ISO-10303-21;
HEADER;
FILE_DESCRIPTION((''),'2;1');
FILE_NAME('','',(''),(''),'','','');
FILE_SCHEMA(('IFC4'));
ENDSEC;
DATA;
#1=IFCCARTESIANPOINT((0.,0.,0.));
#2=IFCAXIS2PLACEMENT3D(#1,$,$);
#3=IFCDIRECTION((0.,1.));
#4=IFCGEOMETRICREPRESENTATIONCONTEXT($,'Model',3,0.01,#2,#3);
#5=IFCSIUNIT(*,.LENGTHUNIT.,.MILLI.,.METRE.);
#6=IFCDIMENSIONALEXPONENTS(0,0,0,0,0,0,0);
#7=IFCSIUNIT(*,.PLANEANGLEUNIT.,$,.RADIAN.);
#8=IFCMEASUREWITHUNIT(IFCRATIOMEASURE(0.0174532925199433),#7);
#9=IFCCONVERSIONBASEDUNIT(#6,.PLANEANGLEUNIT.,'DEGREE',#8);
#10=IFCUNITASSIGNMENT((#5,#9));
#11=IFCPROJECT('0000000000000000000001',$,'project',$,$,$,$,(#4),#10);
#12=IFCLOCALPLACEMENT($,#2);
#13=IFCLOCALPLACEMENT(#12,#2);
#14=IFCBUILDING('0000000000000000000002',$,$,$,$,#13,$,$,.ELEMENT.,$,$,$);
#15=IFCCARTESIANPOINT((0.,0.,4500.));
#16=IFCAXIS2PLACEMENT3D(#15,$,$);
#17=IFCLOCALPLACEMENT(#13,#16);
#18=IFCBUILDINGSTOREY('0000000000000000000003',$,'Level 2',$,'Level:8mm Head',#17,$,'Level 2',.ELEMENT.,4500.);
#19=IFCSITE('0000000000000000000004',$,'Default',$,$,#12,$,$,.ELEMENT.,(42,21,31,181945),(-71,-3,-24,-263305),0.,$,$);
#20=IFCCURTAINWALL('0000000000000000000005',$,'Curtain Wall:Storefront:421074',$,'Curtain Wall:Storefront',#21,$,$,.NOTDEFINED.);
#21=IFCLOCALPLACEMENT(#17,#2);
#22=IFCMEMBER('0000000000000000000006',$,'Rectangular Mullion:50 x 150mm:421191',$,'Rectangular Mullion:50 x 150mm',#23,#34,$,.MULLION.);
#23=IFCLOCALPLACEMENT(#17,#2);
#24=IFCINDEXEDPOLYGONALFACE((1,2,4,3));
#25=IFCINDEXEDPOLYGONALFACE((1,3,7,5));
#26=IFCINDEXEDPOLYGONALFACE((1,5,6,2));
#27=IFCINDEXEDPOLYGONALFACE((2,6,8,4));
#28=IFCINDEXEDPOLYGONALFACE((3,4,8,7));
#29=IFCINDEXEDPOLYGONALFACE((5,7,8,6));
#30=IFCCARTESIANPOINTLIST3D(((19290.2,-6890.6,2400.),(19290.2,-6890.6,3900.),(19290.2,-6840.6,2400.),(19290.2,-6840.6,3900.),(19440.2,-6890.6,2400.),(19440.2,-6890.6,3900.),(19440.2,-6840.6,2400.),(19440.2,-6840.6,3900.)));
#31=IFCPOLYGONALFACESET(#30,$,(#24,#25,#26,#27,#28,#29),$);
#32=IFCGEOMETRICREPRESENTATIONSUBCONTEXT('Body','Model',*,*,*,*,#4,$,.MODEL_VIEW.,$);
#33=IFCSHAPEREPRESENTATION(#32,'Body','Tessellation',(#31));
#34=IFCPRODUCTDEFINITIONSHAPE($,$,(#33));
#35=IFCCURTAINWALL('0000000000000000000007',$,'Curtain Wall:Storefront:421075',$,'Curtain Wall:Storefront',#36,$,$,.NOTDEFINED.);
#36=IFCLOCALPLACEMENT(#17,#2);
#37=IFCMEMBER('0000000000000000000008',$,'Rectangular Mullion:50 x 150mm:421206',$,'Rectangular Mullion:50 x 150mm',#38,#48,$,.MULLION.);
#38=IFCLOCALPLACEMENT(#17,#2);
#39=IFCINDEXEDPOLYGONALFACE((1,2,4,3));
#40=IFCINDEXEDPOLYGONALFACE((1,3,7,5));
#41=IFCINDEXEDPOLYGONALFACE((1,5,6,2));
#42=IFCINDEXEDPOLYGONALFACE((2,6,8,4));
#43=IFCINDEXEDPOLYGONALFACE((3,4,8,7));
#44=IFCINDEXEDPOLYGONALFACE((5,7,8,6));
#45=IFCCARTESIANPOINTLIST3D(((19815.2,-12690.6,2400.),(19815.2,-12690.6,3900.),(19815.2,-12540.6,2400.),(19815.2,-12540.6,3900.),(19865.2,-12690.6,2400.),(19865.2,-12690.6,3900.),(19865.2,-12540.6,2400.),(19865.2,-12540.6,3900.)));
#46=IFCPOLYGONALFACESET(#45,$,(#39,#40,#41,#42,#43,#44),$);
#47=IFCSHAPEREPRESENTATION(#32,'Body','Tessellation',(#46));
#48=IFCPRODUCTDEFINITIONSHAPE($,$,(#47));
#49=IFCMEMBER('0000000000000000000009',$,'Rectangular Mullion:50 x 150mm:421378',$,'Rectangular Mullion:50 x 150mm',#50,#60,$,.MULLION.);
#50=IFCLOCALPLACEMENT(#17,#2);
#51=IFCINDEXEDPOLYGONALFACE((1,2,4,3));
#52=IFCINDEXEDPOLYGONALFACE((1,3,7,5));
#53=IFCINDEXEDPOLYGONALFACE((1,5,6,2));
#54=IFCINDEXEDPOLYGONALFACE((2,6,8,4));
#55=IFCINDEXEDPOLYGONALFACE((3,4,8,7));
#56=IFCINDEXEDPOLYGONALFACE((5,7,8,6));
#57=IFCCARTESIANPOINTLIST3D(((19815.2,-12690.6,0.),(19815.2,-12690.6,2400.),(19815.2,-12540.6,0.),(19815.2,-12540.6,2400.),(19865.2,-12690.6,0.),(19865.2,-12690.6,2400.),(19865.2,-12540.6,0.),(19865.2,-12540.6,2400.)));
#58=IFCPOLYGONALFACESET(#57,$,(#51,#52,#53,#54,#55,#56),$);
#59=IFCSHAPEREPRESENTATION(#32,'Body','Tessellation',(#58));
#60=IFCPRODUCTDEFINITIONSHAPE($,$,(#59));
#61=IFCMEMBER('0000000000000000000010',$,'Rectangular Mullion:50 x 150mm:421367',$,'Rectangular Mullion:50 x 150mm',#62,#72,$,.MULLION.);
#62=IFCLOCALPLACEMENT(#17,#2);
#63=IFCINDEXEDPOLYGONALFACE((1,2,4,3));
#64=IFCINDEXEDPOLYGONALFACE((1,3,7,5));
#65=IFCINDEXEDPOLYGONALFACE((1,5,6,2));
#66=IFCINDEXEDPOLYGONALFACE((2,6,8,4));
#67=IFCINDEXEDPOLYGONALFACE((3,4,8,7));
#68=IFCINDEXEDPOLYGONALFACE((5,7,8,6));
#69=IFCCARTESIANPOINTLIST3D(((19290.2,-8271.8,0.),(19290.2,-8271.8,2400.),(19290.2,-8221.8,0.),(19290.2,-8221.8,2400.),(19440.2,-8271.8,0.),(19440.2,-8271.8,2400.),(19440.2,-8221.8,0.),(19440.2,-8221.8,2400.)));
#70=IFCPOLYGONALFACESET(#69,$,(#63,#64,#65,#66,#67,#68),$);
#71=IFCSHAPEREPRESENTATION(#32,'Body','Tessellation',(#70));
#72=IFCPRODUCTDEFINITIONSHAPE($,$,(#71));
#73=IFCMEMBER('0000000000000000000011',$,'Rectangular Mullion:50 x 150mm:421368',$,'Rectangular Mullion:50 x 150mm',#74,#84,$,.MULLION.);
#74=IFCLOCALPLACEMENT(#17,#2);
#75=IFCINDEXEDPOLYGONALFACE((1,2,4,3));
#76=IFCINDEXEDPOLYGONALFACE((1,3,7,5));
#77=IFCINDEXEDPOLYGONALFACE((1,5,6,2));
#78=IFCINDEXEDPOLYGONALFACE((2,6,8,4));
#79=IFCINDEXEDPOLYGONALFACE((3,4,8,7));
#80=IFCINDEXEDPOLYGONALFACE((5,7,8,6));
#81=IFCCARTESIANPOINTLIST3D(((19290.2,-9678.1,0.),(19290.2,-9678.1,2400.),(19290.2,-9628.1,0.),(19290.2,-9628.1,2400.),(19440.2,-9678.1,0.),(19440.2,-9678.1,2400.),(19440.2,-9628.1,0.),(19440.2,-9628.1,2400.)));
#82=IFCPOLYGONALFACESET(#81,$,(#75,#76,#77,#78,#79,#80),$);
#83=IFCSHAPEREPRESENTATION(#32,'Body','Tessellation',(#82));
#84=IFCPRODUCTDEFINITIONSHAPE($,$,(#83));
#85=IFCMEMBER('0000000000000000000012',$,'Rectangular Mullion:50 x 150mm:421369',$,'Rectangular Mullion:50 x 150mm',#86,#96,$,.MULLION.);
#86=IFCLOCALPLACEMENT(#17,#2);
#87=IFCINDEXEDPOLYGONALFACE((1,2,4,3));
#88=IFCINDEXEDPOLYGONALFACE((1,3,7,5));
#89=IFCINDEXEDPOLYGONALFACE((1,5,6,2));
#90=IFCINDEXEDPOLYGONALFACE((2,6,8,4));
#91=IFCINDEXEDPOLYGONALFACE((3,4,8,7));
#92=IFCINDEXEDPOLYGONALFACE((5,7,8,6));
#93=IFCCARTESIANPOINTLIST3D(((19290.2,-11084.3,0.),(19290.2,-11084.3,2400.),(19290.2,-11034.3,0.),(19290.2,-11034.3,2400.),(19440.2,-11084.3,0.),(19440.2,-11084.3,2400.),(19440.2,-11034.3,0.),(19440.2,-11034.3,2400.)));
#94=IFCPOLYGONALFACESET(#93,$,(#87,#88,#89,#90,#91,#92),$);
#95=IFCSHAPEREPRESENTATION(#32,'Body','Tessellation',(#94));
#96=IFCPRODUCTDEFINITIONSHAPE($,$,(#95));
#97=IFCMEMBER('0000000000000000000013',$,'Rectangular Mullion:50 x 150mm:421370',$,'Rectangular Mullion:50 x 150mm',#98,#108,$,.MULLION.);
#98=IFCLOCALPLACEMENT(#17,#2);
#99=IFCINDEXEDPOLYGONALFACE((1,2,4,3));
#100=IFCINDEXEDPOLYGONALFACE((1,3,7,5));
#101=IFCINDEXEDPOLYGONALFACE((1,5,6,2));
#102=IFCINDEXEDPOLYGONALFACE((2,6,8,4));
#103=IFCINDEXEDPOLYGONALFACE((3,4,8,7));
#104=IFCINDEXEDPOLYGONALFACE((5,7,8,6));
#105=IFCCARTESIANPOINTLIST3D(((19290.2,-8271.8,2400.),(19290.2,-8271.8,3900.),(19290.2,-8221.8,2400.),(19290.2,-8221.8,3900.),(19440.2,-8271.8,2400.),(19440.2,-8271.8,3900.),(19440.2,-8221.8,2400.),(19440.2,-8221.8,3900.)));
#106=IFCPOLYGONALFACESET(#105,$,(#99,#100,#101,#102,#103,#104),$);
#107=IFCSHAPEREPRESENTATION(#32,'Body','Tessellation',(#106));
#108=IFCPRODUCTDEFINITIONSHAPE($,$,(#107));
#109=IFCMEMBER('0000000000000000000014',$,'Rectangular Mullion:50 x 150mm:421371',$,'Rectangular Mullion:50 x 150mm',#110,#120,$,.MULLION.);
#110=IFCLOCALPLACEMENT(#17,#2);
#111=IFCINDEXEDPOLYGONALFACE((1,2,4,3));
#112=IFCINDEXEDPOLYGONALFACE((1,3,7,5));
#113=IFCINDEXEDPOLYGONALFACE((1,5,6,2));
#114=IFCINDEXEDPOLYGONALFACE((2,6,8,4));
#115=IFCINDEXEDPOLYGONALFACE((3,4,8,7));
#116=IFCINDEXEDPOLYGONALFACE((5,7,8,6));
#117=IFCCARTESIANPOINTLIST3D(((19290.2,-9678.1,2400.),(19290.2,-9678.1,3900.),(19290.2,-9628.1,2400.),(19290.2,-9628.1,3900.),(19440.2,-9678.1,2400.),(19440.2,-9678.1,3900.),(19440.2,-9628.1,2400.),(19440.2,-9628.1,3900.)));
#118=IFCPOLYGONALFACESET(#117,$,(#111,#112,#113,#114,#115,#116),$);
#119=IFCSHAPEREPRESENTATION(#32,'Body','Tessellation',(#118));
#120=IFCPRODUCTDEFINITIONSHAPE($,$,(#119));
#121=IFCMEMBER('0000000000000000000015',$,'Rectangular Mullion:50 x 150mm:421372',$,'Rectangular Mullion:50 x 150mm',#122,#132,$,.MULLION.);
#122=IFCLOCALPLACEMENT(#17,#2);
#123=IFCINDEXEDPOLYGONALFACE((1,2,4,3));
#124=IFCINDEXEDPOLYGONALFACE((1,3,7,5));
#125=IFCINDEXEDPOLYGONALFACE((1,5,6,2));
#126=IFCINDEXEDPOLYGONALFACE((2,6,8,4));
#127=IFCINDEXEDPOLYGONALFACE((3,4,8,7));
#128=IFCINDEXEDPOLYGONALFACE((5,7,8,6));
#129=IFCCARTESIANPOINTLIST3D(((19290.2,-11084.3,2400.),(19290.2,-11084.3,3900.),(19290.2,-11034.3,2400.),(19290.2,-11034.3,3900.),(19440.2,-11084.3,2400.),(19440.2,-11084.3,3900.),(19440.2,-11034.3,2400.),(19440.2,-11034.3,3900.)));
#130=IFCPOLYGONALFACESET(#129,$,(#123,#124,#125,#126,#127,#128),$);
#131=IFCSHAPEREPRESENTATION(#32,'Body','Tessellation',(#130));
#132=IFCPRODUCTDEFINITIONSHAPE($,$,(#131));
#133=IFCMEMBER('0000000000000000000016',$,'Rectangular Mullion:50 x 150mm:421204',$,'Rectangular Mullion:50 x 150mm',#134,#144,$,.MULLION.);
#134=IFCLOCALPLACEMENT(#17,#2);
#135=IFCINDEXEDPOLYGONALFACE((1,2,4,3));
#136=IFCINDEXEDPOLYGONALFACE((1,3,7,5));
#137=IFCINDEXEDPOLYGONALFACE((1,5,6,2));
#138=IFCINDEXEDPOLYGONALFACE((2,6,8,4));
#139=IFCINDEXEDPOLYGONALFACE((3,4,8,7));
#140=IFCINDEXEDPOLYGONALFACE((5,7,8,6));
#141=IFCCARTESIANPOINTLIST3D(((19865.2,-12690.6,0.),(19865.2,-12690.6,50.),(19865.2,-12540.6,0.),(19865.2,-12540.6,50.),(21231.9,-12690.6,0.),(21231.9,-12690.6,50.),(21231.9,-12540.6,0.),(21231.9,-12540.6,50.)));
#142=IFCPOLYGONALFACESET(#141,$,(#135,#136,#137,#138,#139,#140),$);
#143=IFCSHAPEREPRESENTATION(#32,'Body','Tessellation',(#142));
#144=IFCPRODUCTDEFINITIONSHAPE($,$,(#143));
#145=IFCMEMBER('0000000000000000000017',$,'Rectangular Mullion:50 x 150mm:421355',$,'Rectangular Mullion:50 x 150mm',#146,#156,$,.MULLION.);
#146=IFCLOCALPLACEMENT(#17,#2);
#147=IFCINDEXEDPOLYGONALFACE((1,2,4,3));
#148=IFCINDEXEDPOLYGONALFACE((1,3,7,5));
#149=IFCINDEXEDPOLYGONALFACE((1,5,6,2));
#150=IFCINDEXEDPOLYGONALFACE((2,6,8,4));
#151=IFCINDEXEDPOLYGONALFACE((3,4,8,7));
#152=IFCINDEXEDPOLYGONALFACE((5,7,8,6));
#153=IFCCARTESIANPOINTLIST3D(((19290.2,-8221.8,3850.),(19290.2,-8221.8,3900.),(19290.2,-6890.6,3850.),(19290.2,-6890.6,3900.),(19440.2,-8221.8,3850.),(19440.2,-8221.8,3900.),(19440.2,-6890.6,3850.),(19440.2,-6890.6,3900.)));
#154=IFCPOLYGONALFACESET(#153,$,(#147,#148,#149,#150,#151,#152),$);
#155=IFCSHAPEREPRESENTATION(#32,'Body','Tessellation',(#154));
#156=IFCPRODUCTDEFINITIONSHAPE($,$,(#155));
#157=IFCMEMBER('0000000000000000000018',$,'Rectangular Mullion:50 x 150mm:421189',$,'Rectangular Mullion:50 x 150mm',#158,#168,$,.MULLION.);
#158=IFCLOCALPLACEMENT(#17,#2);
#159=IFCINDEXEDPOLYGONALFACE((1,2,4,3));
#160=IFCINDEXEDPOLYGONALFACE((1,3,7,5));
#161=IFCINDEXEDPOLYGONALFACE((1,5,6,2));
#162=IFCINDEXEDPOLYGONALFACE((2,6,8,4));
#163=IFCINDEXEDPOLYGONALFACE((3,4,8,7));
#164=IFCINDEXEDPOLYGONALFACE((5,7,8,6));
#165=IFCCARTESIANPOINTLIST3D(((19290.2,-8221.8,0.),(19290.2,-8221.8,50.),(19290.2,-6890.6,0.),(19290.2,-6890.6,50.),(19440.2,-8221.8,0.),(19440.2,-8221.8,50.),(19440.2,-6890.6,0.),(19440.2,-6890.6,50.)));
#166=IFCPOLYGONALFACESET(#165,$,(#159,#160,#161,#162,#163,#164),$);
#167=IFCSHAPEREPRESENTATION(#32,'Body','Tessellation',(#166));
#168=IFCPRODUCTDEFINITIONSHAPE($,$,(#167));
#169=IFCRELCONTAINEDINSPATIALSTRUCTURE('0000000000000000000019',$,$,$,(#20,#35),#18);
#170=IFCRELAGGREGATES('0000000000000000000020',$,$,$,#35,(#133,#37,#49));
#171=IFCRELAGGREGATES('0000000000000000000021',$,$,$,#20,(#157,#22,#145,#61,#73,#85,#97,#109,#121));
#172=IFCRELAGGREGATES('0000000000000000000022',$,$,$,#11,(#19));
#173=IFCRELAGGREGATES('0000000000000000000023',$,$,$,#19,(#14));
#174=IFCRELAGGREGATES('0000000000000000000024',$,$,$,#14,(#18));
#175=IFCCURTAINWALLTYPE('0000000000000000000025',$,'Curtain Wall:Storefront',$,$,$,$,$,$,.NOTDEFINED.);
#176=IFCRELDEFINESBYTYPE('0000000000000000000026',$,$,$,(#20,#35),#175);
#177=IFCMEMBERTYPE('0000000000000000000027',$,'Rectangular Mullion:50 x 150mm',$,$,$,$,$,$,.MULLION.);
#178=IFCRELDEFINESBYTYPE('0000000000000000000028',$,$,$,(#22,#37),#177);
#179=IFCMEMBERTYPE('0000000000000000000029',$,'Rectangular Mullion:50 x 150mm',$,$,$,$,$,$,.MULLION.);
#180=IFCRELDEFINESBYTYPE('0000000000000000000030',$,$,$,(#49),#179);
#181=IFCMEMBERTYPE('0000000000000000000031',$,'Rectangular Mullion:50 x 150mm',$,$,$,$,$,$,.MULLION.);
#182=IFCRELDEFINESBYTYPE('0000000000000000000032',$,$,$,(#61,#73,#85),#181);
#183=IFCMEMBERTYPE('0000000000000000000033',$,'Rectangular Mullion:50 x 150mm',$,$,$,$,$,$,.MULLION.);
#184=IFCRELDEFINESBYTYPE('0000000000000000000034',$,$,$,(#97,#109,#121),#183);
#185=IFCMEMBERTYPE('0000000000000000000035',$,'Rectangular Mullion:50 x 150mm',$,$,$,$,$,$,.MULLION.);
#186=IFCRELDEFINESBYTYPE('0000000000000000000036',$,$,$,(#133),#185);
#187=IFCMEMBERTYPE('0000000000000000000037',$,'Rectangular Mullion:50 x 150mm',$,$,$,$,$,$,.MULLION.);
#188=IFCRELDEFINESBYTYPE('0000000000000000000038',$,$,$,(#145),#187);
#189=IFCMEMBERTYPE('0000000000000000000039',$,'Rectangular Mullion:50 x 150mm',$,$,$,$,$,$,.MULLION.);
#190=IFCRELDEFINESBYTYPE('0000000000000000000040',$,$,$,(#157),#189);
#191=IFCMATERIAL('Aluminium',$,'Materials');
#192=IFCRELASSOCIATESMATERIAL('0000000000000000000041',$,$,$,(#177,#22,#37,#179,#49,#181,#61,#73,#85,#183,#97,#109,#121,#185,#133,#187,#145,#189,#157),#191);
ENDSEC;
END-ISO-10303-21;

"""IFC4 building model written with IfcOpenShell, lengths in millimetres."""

from ifc_helpers import new_model, entity, si_unit, converted_unit, direction, frame, origin, place, context, subcontext, project, spatial, indexed_curve, outline, extrude, source, transform, mapped, material, type_object, type_shapes, element, aggregate, save


model = new_model("IFC4")

# Units and contexts
model_context = context("Model", 3, precision=0.01, world=origin(), true_north=direction((0.0, 1.0)))
body_context = subcontext(model_context, "Body", "Model", "MODEL_VIEW")
ifc_project = project(units=[si_unit("LENGTHUNIT", "METRE", prefix="MILLI"), converted_unit("PLANEANGLEUNIT", "DEGREE", entity("IfcRatioMeasure", 0.0174532925199433), si_unit("PLANEANGLEUNIT", "RADIAN"), dimensions=[0, 0, 0, 0, 0, 0, 0])], contexts=[model_context])

# Site, building, storey
site_placement = place(None, origin())
site = spatial("IfcSite", under=ifc_project, at=site_placement, Name="Default", CompositionType="ELEMENT", RefLatitude=(42, 21, 31, 181945), RefLongitude=(-71, -3, -24, -263305), RefElevation=0.0)
building_placement = place(site_placement, origin())
building = spatial("IfcBuilding", under=site, at=building_placement, CompositionType="ELEMENT")
storey_placement = place(building_placement, frame((0.0, 0.0, 4500.0)))
storey = spatial("IfcBuildingStorey", under=building, at=storey_placement, Name="Level 2", ObjectType="Level:8mm Head", LongName="Level 2", CompositionType="ELEMENT", Elevation=4500.0)

# Curtain wall, member
curtain_wall_type_1 = type_object("IfcCurtainWallType", Name="Curtain Wall:Storefront", PredefinedType="NOTDEFINED")
curtain_wall_1_placement = place(storey_placement, frame((0.0, 0.0, -4500.0)))
curtain_wall_1 = element("IfcCurtainWall", 1, at=curtain_wall_1_placement, inside=storey, type_object=curtain_wall_type_1, Name="Curtain Wall:Storefront:421074", ObjectType="Curtain Wall:Storefront", PredefinedType="NOTDEFINED")
ifc_material_1 = material(Name="Aluminium", Category="Materials")
member_type_1 = type_object("IfcMemberType", Name="Rectangular Mullion:50 x 150mm", PredefinedType="MULLION", material=ifc_material_1)
shared_shape_1 = source(origin(), body_context, "Body", "SweptSolid", [
    extrude(outline(indexed_curve([(-75.0, -25.0), (75.0, -25.0), (75.0, 25.0), (-75.0, 25.0), (-75.0, -25.0)], self_intersect=False)), frame((-25.0, 0.0, -1500.0), z_axis=(0.0, 0.0, 1.0), x_axis=(0.0, -1.0, 0.0)), (0.0, 0.0, 1.0), 1500.0),
])
type_shapes(member_type_1, [shared_shape_1])
member_1_placement = place(storey_placement, frame((19365.2, -6840.6, 3900.0), z_axis=(0.0, 0.0, 1.0), x_axis=(0.0, 1.0, 0.0)))
member_1 = element("IfcMember", 2, at=member_1_placement, type_object=member_type_1, material=ifc_material_1, Name="Rectangular Mullion:50 x 150mm:421191", ObjectType="Rectangular Mullion:50 x 150mm", PredefinedType="MULLION", context=body_context, shape_type="MappedRepresentation", body=[
    mapped(shared_shape_1, transform((0.0, 0.0, 0.0), scale=1.0)),
])

# Curtain wall, members
curtain_wall_2_placement = place(storey_placement, frame((0.0, 0.0, -4500.0)))
curtain_wall_2 = element("IfcCurtainWall", 3, at=curtain_wall_2_placement, inside=storey, type_object=curtain_wall_type_1, Name="Curtain Wall:Storefront:421075", ObjectType="Curtain Wall:Storefront", PredefinedType="NOTDEFINED")
member_2_placement = place(storey_placement, frame((19815.2, -12615.6, 3900.0), z_axis=(0.0, 0.0, 1.0), x_axis=(-1.0, 0.0, 0.0)))
member_2 = element("IfcMember", 4, at=member_2_placement, type_object=member_type_1, material=ifc_material_1, Name="Rectangular Mullion:50 x 150mm:421206", ObjectType="Rectangular Mullion:50 x 150mm", PredefinedType="MULLION", context=body_context, shape_type="MappedRepresentation", body=[
    mapped(shared_shape_1, transform((0.0, 0.0, 0.0), scale=1.0)),
])
member_type_2 = type_object("IfcMemberType", Name="Rectangular Mullion:50 x 150mm", PredefinedType="MULLION", material=ifc_material_1)
shared_shape_2 = source(origin(), body_context, "Body", "SweptSolid", [
    extrude(outline(indexed_curve([(-75.0, -25.0), (75.0, -25.0), (75.0, 25.0), (-75.0, 25.0), (-75.0, -25.0)], self_intersect=False)), frame((-25.0, 0.0, -2400.0), z_axis=(0.0, 0.0, 1.0), x_axis=(0.0, -1.0, 0.0)), (0.0, 0.0, 1.0), 2400.0),
])
type_shapes(member_type_2, [shared_shape_2])
member_3_placement = place(storey_placement, frame((19815.2, -12615.6, 2400.0), z_axis=(0.0, 0.0, 1.0), x_axis=(-1.0, 0.0, 0.0)))
member_3 = element("IfcMember", 5, at=member_3_placement, type_object=member_type_2, material=ifc_material_1, Name="Rectangular Mullion:50 x 150mm:421378", ObjectType="Rectangular Mullion:50 x 150mm", PredefinedType="MULLION", context=body_context, shape_type="MappedRepresentation", body=[
    mapped(shared_shape_2, transform((0.0, 0.0, 0.0), scale=1.0)),
])

# Members
member_type_3 = type_object("IfcMemberType", Name="Rectangular Mullion:50 x 150mm", PredefinedType="MULLION", material=ifc_material_1)
shared_shape_3 = source(origin(), body_context, "Body", "SweptSolid", [
    extrude(outline(indexed_curve([(-75.0, -25.0), (75.0, -25.0), (75.0, 25.0), (-75.0, 25.0), (-75.0, -25.0)], self_intersect=False)), frame((0.0, 0.0, -2400.0), z_axis=(0.0, 0.0, 1.0), x_axis=(0.0, -1.0, 0.0)), (0.0, 0.0, 1.0), 2400.0),
])
type_shapes(member_type_3, [shared_shape_3])
member_4_placement = place(storey_placement, frame((19365.2, -8246.8, 0.0), z_axis=(0.0, 0.0, -1.0), x_axis=(0.0, -1.0, 0.0)))
member_4 = element("IfcMember", 6, at=member_4_placement, type_object=member_type_3, material=ifc_material_1, Name="Rectangular Mullion:50 x 150mm:421367", ObjectType="Rectangular Mullion:50 x 150mm", PredefinedType="MULLION", context=body_context, shape_type="MappedRepresentation", body=[
    mapped(shared_shape_3, transform((0.0, 0.0, 0.0), scale=1.0)),
])
member_5_placement = place(storey_placement, frame((19365.2, -9653.1, 0.0), z_axis=(0.0, 0.0, -1.0), x_axis=(0.0, -1.0, 0.0)))
member_5 = element("IfcMember", 7, at=member_5_placement, type_object=member_type_3, material=ifc_material_1, Name="Rectangular Mullion:50 x 150mm:421368", ObjectType="Rectangular Mullion:50 x 150mm", PredefinedType="MULLION", context=body_context, shape_type="MappedRepresentation", body=[
    mapped(shared_shape_3, transform((0.0, 0.0, 0.0), scale=1.0)),
])
member_6_placement = place(storey_placement, frame((19365.2, -11059.3, 0.0), z_axis=(0.0, 0.0, -1.0), x_axis=(0.0, -1.0, 0.0)))
member_6 = element("IfcMember", 8, at=member_6_placement, type_object=member_type_3, material=ifc_material_1, Name="Rectangular Mullion:50 x 150mm:421369", ObjectType="Rectangular Mullion:50 x 150mm", PredefinedType="MULLION", context=body_context, shape_type="MappedRepresentation", body=[
    mapped(shared_shape_3, transform((0.0, 0.0, 0.0), scale=1.0)),
])
member_type_4 = type_object("IfcMemberType", Name="Rectangular Mullion:50 x 150mm", PredefinedType="MULLION", material=ifc_material_1)
shared_shape_4 = source(origin(), body_context, "Body", "SweptSolid", [
    extrude(outline(indexed_curve([(-75.0, -25.0), (75.0, -25.0), (75.0, 25.0), (-75.0, 25.0), (-75.0, -25.0)], self_intersect=False)), frame((0.0, 0.0, -1500.0), z_axis=(0.0, 0.0, 1.0), x_axis=(0.0, -1.0, 0.0)), (0.0, 0.0, 1.0), 1500.0),
])
type_shapes(member_type_4, [shared_shape_4])
member_7_placement = place(storey_placement, frame((19365.2, -8246.8, 2400.0), z_axis=(0.0, 0.0, -1.0), x_axis=(0.0, -1.0, 0.0)))
member_7 = element("IfcMember", 9, at=member_7_placement, type_object=member_type_4, material=ifc_material_1, Name="Rectangular Mullion:50 x 150mm:421370", ObjectType="Rectangular Mullion:50 x 150mm", PredefinedType="MULLION", context=body_context, shape_type="MappedRepresentation", body=[
    mapped(shared_shape_4, transform((0.0, 0.0, 0.0), scale=1.0)),
])
member_8_placement = place(storey_placement, frame((19365.2, -9653.1, 2400.0), z_axis=(0.0, 0.0, -1.0), x_axis=(0.0, -1.0, 0.0)))
member_8 = element("IfcMember", 10, at=member_8_placement, type_object=member_type_4, material=ifc_material_1, Name="Rectangular Mullion:50 x 150mm:421371", ObjectType="Rectangular Mullion:50 x 150mm", PredefinedType="MULLION", context=body_context, shape_type="MappedRepresentation", body=[
    mapped(shared_shape_4, transform((0.0, 0.0, 0.0), scale=1.0)),
])
member_9_placement = place(storey_placement, frame((19365.2, -11059.3, 2400.0), z_axis=(0.0, 0.0, -1.0), x_axis=(0.0, -1.0, 0.0)))
member_9 = element("IfcMember", 11, at=member_9_placement, type_object=member_type_4, material=ifc_material_1, Name="Rectangular Mullion:50 x 150mm:421372", ObjectType="Rectangular Mullion:50 x 150mm", PredefinedType="MULLION", context=body_context, shape_type="MappedRepresentation", body=[
    mapped(shared_shape_4, transform((0.0, 0.0, 0.0), scale=1.0)),
])
member_type_5 = type_object("IfcMemberType", Name="Rectangular Mullion:50 x 150mm", PredefinedType="MULLION", material=ifc_material_1)
shared_shape_5 = source(origin(), body_context, "Body", "SweptSolid", [
    extrude(outline(indexed_curve([(-75.0, -25.0), (75.0, -25.0), (75.0, 25.0), (-75.0, 25.0), (-75.0, -25.0)], self_intersect=False)), frame((-25.0, 0.0, -1366.7), z_axis=(0.0, 0.0, 1.0), x_axis=(0.0, -1.0, 0.0)), (0.0, 0.0, 1.0), 1366.7),
])
type_shapes(member_type_5, [shared_shape_5])
member_10_placement = place(storey_placement, frame((19865.2, -12615.6, 0.0), z_axis=(-1.0, 0.0, 0.0), x_axis=(0.0, 0.0, -1.0)))
member_10 = element("IfcMember", 12, at=member_10_placement, type_object=member_type_5, material=ifc_material_1, Name="Rectangular Mullion:50 x 150mm:421204", ObjectType="Rectangular Mullion:50 x 150mm", PredefinedType="MULLION", context=body_context, shape_type="MappedRepresentation", body=[
    mapped(shared_shape_5, transform((0.0, 0.0, 0.0), scale=1.0)),
])
member_type_6 = type_object("IfcMemberType", Name="Rectangular Mullion:50 x 150mm", PredefinedType="MULLION", material=ifc_material_1)
shared_shape_6 = source(origin(), body_context, "Body", "SweptSolid", [
    extrude(outline(indexed_curve([(-75.0, -25.0), (75.0, -25.0), (75.0, 25.0), (-75.0, 25.0), (-75.0, -25.0)], self_intersect=False)), frame((-25.0, 0.0, -1331.3), z_axis=(0.0, 0.0, 1.0), x_axis=(0.0, -1.0, 0.0)), (0.0, 0.0, 1.0), 1331.3),
])
type_shapes(member_type_6, [shared_shape_6])
member_11_placement = place(storey_placement, frame((19365.2, -8221.8, 3900.0), z_axis=(0.0, -1.0, 0.0), x_axis=(0.0, 0.0, 1.0)))
member_11 = element("IfcMember", 13, at=member_11_placement, type_object=member_type_6, material=ifc_material_1, Name="Rectangular Mullion:50 x 150mm:421355", ObjectType="Rectangular Mullion:50 x 150mm", PredefinedType="MULLION", context=body_context, shape_type="MappedRepresentation", body=[
    mapped(shared_shape_6, transform((0.0, 0.0, 0.0), scale=1.0)),
])
member_type_7 = type_object("IfcMemberType", Name="Rectangular Mullion:50 x 150mm", PredefinedType="MULLION", material=ifc_material_1)
shared_shape_7 = source(origin(), body_context, "Body", "SweptSolid", [
    extrude(outline(indexed_curve([(-75.0, -25.0), (75.0, -25.0), (75.0, 25.0), (-75.0, 25.0), (-75.0, -25.0)], self_intersect=False)), frame((-25.0, 0.0, -1331.3), z_axis=(0.0, 0.0, 1.0), x_axis=(0.0, -1.0, 0.0)), (0.0, 0.0, 1.0), 1331.3),
])
type_shapes(member_type_7, [shared_shape_7])
member_12_placement = place(storey_placement, frame((19365.2, -6890.6, 0.0), z_axis=(0.0, 1.0, 0.0), x_axis=(0.0, 0.0, -1.0)))
member_12 = element("IfcMember", 14, at=member_12_placement, type_object=member_type_7, material=ifc_material_1, Name="Rectangular Mullion:50 x 150mm:421189", ObjectType="Rectangular Mullion:50 x 150mm", PredefinedType="MULLION", context=body_context, shape_type="MappedRepresentation", body=[
    mapped(shared_shape_7, transform((0.0, 0.0, 0.0), scale=1.0)),
])

aggregate(curtain_wall_2, [member_10, member_2, member_3])
aggregate(curtain_wall_1, [member_12, member_1, member_11, member_4, member_5, member_6, member_7, member_8, member_9])

save(model, "model.ifc")
